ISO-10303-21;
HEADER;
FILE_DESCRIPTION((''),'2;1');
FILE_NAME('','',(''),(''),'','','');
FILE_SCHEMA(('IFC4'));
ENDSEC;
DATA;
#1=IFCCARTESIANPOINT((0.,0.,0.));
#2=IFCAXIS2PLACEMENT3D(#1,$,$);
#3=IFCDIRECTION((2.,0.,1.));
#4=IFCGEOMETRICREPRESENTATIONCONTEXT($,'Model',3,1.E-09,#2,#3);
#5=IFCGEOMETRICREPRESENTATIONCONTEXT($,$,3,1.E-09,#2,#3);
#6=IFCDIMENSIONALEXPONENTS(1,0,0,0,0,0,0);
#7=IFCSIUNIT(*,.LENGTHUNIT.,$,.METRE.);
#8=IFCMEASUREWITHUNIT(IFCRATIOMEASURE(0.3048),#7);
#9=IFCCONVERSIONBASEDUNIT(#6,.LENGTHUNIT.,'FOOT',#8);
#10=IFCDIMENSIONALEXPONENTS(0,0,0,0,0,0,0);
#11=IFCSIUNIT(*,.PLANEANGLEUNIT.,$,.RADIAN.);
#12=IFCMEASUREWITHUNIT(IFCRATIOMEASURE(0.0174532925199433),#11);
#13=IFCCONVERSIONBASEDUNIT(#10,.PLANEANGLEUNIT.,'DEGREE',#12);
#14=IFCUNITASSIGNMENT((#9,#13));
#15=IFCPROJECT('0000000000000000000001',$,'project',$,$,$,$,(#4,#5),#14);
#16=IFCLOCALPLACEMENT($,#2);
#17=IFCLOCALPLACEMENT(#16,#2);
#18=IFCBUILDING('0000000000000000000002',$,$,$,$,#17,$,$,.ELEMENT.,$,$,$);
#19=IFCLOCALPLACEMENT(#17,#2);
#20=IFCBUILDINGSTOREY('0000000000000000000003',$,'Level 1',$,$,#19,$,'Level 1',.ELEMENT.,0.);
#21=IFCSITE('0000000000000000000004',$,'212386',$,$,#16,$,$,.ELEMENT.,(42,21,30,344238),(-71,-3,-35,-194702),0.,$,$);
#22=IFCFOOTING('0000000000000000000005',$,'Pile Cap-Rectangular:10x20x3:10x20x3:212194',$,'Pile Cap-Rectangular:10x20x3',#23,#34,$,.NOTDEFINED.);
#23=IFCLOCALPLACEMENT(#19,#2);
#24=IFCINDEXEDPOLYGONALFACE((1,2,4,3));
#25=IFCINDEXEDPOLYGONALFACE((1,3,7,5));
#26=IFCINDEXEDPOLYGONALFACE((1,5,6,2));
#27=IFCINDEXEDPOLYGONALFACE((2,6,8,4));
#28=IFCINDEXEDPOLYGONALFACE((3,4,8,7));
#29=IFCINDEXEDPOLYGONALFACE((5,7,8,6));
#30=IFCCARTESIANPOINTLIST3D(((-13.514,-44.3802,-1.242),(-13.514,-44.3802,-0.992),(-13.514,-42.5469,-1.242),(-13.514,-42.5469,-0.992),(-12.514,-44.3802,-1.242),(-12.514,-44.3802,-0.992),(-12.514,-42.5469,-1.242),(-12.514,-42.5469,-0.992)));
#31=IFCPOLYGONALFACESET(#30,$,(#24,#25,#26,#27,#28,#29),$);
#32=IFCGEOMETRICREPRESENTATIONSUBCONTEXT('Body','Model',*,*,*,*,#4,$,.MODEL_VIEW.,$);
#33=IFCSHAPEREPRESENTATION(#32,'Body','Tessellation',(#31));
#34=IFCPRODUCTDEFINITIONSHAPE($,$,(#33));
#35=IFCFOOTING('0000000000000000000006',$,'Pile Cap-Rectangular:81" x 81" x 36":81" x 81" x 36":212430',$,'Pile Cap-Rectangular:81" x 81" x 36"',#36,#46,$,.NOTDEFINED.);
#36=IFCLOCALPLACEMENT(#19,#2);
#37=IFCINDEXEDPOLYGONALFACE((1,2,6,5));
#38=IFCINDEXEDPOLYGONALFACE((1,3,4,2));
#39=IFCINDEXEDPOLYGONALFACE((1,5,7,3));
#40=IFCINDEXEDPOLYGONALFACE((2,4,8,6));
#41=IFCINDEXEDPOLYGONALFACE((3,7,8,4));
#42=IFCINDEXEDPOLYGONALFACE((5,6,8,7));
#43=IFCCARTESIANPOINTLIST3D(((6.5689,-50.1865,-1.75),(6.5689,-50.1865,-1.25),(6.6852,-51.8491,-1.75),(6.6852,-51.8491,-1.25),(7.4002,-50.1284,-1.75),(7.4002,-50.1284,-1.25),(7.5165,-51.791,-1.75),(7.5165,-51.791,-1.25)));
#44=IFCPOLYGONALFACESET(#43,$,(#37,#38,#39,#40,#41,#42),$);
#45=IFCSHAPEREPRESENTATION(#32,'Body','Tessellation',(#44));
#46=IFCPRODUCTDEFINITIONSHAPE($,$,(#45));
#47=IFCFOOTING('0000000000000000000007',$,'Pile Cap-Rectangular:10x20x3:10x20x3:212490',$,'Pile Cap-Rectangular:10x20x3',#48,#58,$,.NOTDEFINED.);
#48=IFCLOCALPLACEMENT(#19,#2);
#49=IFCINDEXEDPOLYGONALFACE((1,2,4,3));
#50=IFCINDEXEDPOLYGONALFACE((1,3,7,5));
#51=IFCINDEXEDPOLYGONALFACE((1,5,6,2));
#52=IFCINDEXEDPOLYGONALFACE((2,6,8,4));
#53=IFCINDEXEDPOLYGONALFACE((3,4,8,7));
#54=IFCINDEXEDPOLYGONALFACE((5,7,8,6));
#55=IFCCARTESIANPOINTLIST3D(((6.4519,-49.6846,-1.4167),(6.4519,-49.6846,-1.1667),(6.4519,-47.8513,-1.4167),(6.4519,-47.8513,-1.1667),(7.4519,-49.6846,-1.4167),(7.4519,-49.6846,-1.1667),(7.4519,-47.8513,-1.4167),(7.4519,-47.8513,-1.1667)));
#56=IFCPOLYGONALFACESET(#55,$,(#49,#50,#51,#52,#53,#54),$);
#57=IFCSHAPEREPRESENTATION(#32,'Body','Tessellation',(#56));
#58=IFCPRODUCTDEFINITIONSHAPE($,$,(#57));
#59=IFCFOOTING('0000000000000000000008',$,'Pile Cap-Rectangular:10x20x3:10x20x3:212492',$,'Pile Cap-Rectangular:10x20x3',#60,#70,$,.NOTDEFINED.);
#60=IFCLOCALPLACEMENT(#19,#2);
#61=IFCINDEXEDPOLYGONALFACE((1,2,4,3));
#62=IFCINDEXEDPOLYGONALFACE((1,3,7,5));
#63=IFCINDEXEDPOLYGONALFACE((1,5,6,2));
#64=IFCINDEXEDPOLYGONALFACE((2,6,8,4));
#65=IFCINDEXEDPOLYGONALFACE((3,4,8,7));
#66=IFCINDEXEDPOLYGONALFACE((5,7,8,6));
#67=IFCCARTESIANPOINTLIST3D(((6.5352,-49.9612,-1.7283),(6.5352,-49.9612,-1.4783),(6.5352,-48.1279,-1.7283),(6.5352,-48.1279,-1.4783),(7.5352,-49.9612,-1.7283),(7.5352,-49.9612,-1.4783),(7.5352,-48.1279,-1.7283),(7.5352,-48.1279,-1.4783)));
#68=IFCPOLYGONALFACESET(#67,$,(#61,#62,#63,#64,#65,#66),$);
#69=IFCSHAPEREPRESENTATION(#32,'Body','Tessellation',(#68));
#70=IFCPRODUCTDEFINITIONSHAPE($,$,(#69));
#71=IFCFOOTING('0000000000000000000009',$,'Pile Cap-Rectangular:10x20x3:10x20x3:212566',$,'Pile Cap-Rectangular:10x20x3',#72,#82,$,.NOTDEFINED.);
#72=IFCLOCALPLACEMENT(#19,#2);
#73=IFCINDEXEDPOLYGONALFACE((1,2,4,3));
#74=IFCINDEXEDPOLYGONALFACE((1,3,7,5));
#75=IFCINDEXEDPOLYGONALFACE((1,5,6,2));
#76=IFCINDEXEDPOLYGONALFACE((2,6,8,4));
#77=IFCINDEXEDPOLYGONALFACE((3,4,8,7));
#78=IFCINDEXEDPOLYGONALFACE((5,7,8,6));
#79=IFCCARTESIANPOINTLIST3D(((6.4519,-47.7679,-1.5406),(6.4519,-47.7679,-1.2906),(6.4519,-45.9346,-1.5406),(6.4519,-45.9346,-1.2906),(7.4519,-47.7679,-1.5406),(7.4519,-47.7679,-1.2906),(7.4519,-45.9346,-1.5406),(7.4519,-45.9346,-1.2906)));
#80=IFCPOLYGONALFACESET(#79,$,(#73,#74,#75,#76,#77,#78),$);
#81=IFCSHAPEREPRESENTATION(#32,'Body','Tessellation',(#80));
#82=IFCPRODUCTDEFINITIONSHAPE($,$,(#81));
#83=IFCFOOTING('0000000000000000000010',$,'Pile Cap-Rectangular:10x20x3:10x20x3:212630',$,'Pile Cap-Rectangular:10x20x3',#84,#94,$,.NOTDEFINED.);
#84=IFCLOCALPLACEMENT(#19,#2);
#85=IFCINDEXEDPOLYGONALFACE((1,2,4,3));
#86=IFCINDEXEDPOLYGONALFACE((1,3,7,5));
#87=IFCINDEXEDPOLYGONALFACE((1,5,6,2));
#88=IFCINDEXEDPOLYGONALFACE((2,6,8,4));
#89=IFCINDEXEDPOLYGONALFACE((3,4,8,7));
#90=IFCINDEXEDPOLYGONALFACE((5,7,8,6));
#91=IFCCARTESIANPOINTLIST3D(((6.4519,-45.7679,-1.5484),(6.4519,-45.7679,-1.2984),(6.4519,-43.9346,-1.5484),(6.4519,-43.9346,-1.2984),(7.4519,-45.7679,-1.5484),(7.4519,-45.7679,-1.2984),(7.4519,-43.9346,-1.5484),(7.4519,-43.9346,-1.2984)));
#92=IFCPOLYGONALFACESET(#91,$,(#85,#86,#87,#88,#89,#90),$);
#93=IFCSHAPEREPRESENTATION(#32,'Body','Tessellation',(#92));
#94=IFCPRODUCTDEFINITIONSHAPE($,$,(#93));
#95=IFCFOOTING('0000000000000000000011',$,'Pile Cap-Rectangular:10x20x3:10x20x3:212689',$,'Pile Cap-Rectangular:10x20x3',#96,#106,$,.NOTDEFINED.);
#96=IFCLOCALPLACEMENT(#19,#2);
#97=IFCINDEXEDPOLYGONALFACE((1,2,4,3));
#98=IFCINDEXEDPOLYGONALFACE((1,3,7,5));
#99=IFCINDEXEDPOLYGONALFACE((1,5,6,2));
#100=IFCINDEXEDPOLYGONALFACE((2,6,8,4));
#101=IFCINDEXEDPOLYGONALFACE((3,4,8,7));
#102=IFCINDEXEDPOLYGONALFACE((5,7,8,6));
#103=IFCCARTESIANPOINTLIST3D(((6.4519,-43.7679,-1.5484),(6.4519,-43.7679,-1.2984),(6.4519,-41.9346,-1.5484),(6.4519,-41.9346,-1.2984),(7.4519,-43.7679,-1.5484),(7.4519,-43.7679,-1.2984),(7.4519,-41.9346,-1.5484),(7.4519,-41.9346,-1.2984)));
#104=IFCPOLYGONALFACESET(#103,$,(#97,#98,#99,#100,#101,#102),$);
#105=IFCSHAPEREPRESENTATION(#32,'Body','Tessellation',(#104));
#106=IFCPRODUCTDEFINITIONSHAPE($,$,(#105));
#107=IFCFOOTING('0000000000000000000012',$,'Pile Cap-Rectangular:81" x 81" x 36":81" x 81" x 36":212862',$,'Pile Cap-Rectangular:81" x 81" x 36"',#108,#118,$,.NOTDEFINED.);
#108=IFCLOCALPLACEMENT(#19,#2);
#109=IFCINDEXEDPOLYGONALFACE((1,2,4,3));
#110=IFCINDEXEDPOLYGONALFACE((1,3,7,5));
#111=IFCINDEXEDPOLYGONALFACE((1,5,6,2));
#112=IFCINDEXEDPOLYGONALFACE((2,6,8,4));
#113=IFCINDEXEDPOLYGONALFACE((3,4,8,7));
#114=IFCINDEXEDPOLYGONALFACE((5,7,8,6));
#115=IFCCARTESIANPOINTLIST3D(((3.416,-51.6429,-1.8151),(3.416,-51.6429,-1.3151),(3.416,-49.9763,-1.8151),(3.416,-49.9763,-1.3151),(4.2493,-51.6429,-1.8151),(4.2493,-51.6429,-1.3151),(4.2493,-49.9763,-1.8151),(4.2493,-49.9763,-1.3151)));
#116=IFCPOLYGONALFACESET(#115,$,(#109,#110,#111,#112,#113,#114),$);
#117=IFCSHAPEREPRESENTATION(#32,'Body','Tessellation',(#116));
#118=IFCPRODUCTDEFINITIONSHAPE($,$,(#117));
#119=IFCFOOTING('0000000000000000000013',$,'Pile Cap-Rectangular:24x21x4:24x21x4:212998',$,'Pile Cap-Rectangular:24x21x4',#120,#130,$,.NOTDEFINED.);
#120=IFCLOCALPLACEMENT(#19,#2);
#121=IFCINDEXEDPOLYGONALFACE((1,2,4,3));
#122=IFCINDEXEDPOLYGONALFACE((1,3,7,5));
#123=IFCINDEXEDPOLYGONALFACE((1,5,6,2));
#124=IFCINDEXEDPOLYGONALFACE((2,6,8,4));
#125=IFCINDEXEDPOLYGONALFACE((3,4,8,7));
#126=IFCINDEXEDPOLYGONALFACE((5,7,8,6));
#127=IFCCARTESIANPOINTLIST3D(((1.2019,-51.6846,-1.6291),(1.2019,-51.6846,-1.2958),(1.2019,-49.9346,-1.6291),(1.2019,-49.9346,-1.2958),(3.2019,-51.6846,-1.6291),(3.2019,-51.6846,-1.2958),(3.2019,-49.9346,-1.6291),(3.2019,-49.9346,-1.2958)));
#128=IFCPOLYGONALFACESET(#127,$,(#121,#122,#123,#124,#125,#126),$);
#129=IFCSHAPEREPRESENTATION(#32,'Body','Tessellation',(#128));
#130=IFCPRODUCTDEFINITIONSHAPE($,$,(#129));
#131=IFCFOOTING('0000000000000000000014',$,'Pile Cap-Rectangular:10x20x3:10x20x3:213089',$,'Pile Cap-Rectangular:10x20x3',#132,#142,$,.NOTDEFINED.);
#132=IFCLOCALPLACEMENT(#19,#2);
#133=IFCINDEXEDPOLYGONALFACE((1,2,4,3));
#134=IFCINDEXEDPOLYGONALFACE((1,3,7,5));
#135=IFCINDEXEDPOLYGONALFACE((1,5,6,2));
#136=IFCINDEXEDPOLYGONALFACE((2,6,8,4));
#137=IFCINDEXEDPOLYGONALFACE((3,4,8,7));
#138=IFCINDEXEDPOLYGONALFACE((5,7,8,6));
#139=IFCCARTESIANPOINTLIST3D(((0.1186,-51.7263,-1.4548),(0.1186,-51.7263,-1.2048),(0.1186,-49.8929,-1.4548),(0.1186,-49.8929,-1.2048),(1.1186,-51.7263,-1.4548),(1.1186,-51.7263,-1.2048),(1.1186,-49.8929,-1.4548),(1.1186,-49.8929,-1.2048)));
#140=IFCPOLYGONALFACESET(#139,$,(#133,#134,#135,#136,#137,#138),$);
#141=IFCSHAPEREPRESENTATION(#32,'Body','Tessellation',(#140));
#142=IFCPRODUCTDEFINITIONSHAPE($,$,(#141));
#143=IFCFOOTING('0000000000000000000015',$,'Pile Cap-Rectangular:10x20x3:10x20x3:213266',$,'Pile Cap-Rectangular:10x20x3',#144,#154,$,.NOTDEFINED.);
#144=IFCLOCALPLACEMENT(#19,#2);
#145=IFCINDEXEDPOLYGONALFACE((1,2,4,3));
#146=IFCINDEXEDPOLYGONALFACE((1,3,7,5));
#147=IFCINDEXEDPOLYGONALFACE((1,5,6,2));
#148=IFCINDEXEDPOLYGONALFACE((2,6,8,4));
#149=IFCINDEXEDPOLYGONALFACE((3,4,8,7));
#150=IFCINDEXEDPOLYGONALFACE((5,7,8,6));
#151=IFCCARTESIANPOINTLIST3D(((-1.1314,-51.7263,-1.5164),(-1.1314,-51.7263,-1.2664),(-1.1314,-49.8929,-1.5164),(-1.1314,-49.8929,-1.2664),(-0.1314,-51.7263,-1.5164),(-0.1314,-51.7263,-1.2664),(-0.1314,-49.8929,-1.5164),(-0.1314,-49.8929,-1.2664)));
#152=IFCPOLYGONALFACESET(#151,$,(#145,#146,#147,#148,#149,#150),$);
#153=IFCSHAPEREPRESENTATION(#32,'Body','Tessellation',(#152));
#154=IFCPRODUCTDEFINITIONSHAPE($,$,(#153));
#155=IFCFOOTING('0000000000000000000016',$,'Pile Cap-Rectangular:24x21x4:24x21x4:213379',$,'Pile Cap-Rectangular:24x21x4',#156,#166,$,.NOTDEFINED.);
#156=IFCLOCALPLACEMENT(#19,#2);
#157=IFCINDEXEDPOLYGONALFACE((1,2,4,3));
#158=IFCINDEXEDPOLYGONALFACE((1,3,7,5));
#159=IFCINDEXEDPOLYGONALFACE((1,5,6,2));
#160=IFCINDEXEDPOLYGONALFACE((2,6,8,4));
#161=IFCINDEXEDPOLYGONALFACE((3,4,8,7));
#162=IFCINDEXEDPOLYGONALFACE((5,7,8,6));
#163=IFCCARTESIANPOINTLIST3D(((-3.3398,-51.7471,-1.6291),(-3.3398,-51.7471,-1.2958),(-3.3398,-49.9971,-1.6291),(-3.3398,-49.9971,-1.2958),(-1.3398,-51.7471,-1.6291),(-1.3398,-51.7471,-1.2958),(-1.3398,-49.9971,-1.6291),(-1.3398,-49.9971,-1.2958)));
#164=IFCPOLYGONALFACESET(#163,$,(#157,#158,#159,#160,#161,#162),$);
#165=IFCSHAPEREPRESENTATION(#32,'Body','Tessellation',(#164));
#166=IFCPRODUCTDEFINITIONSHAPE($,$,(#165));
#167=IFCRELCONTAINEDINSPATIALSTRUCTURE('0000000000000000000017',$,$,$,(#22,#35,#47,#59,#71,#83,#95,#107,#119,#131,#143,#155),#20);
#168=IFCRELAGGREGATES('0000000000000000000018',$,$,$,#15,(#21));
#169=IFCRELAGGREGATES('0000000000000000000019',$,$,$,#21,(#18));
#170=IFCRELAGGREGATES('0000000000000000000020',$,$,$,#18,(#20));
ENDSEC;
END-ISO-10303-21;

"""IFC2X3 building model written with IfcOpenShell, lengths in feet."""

from ifc_helpers import new_model, entity, si_unit, converted_unit, direction, frame, frame_2d, origin, origin_2d_with_axis, place, context, subcontext, project, spatial, rectangle, extrude, element, save


model = new_model("IFC2X3")

# Units and contexts
model_context = context("Model", 3, precision=1e-09, world=origin(), true_north=direction((2.0, 0.0, 1.0)))
context_of_model = context(None, 3, precision=1e-09, world=origin(), true_north=direction((2.0, 0.0, 1.0)))
body_context = subcontext(model_context, "Body", "Model", "MODEL_VIEW")
ifc_project = project(units=[converted_unit("LENGTHUNIT", "FOOT", entity("IfcRatioMeasure", 0.3048), si_unit("LENGTHUNIT", "METRE"), dimensions=[1, 0, 0, 0, 0, 0, 0]), converted_unit("PLANEANGLEUNIT", "DEGREE", entity("IfcRatioMeasure", 0.0174532925199433), si_unit("PLANEANGLEUNIT", "RADIAN"), dimensions=[0, 0, 0, 0, 0, 0, 0])], contexts=[model_context, context_of_model])

# Site, building, storey
site_placement = place(None, origin())
site = spatial("IfcSite", under=ifc_project, at=site_placement, Name="212386", CompositionType="ELEMENT", RefLatitude=(42, 21, 30, 344238), RefLongitude=(-71, -3, -35, -194702), RefElevation=0.0)
building_placement = place(site_placement, origin())
building = spatial("IfcBuilding", under=site, at=building_placement, CompositionType="ELEMENT")
storey_placement = place(building_placement, origin())
storey = spatial("IfcBuildingStorey", under=building, at=storey_placement, Name="Level 1", LongName="Level 1", CompositionType="ELEMENT", Elevation=0.0)

# Footings
footing_1_placement = place(storey_placement, origin())
element("IfcFooting", 1, at=footing_1_placement, inside=storey, Name="Pile Cap-Rectangular:10x20x3:10x20x3:212194", ObjectType="Pile Cap-Rectangular:10x20x3", PredefinedType="NOTDEFINED", context=body_context, shape_type="SweptSolid", body=[
    extrude(rectangle(XDim=1.0, YDim=1.8333, at=frame_2d((0.0, 0.0), x_axis=(1.0, 0.0))), frame((-13.014, -43.4636, -1.242), z_axis=(0.0, 0.0, 1.0), x_axis=(-1.0, 0.0, 0.0)), (0.0, 0.0, 1.0), 0.25),
])
footing_2_placement = place(storey_placement, origin())
element("IfcFooting", 2, at=footing_2_placement, inside=storey, Name="Pile Cap-Rectangular:81\" x 81\" x 36\":81\" x 81\" x 36\":212430", ObjectType="Pile Cap-Rectangular:81\" x 81\" x 36\"", PredefinedType="NOTDEFINED", context=body_context, shape_type="SweptSolid", body=[
    extrude(rectangle(XDim=0.8333, YDim=1.6667, at=origin_2d_with_axis()), frame((7.0427, -50.9887, -1.75), z_axis=(0.0, 0.0, 1.0), x_axis=(-0.997564, -0.069756, 0.0)), (0.0, 0.0, 1.0), 0.5),
])
footing_3_placement = place(storey_placement, origin())
element("IfcFooting", 3, at=footing_3_placement, inside=storey, Name="Pile Cap-Rectangular:10x20x3:10x20x3:212490", ObjectType="Pile Cap-Rectangular:10x20x3", PredefinedType="NOTDEFINED", context=body_context, shape_type="SweptSolid", body=[
    extrude(rectangle(XDim=1.0, YDim=1.8333, at=frame_2d((0.0, 0.0), x_axis=(1.0, 0.0))), frame((6.9519, -48.7679, -1.4167), z_axis=(0.0, 0.0, 1.0), x_axis=(-1.0, 0.0, 0.0)), (0.0, 0.0, 1.0), 0.25),
])
footing_4_placement = place(storey_placement, origin())
element("IfcFooting", 4, at=footing_4_placement, inside=storey, Name="Pile Cap-Rectangular:10x20x3:10x20x3:212492", ObjectType="Pile Cap-Rectangular:10x20x3", PredefinedType="NOTDEFINED", context=body_context, shape_type="SweptSolid", body=[
    extrude(rectangle(XDim=1.0, YDim=1.8333, at=frame_2d((0.0, 0.0), x_axis=(1.0, 0.0))), frame((7.0352, -49.0446, -1.7283), z_axis=(0.0, 0.0, 1.0), x_axis=(-1.0, 0.0, 0.0)), (0.0, 0.0, 1.0), 0.25),
])
footing_5_placement = place(storey_placement, origin())
element("IfcFooting", 5, at=footing_5_placement, inside=storey, Name="Pile Cap-Rectangular:10x20x3:10x20x3:212566", ObjectType="Pile Cap-Rectangular:10x20x3", PredefinedType="NOTDEFINED", context=body_context, shape_type="SweptSolid", body=[
    extrude(rectangle(XDim=1.0, YDim=1.8333, at=frame_2d((0.0, 0.0), x_axis=(1.0, 0.0))), frame((6.9519, -46.8513, -1.5406), z_axis=(0.0, 0.0, 1.0), x_axis=(-1.0, 0.0, 0.0)), (0.0, 0.0, 1.0), 0.25),
])
footing_6_placement = place(storey_placement, origin())
element("IfcFooting", 6, at=footing_6_placement, inside=storey, Name="Pile Cap-Rectangular:10x20x3:10x20x3:212630", ObjectType="Pile Cap-Rectangular:10x20x3", PredefinedType="NOTDEFINED", context=body_context, shape_type="SweptSolid", body=[
    extrude(rectangle(XDim=1.0, YDim=1.8333, at=frame_2d((0.0, 0.0), x_axis=(1.0, 0.0))), frame((6.9519, -44.8513, -1.5484), z_axis=(0.0, 0.0, 1.0), x_axis=(-1.0, 0.0, 0.0)), (0.0, 0.0, 1.0), 0.25),
])
footing_7_placement = place(storey_placement, origin())
element("IfcFooting", 7, at=footing_7_placement, inside=storey, Name="Pile Cap-Rectangular:10x20x3:10x20x3:212689", ObjectType="Pile Cap-Rectangular:10x20x3", PredefinedType="NOTDEFINED", context=body_context, shape_type="SweptSolid", body=[
    extrude(rectangle(XDim=1.0, YDim=1.8333, at=frame_2d((0.0, 0.0), x_axis=(1.0, 0.0))), frame((6.9519, -42.8513, -1.5484), z_axis=(0.0, 0.0, 1.0), x_axis=(-1.0, 0.0, 0.0)), (0.0, 0.0, 1.0), 0.25),
])
footing_8_placement = place(storey_placement, origin())
element("IfcFooting", 8, at=footing_8_placement, inside=storey, Name="Pile Cap-Rectangular:81\" x 81\" x 36\":81\" x 81\" x 36\":212862", ObjectType="Pile Cap-Rectangular:81\" x 81\" x 36\"", PredefinedType="NOTDEFINED", context=body_context, shape_type="SweptSolid", body=[
    extrude(rectangle(XDim=0.8333, YDim=1.6667, at=frame_2d((0.0, 0.0), x_axis=(1.0, 0.0))), frame((3.8327, -50.8096, -1.8151), z_axis=(0.0, 0.0, 1.0), x_axis=(-1.0, 0.0, 0.0)), (0.0, 0.0, 1.0), 0.5),
])
footing_9_placement = place(storey_placement, origin())
element("IfcFooting", 9, at=footing_9_placement, inside=storey, Name="Pile Cap-Rectangular:24x21x4:24x21x4:212998", ObjectType="Pile Cap-Rectangular:24x21x4", PredefinedType="NOTDEFINED", context=body_context, shape_type="SweptSolid", body=[
    extrude(rectangle(XDim=2.0, YDim=1.75, at=origin_2d_with_axis()), frame((2.2019, -50.8096, -1.6291), z_axis=(0.0, 0.0, 1.0), x_axis=(-1.0, 0.0, 0.0)), (0.0, 0.0, 1.0), 0.3333),
])
footing_10_placement = place(storey_placement, origin())
element("IfcFooting", 10, at=footing_10_placement, inside=storey, Name="Pile Cap-Rectangular:10x20x3:10x20x3:213089", ObjectType="Pile Cap-Rectangular:10x20x3", PredefinedType="NOTDEFINED", context=body_context, shape_type="SweptSolid", body=[
    extrude(rectangle(XDim=1.0, YDim=1.8333, at=frame_2d((0.0, 0.0), x_axis=(1.0, 0.0))), frame((0.6186, -50.8096, -1.4548), z_axis=(0.0, 0.0, 1.0), x_axis=(-1.0, 0.0, 0.0)), (0.0, 0.0, 1.0), 0.25),
])
footing_11_placement = place(storey_placement, origin())
element("IfcFooting", 11, at=footing_11_placement, inside=storey, Name="Pile Cap-Rectangular:10x20x3:10x20x3:213266", ObjectType="Pile Cap-Rectangular:10x20x3", PredefinedType="NOTDEFINED", context=body_context, shape_type="SweptSolid", body=[
    extrude(rectangle(XDim=1.0, YDim=1.8333, at=frame_2d((0.0, 0.0), x_axis=(1.0, 0.0))), frame((-0.6314, -50.8096, -1.5164), z_axis=(0.0, 0.0, 1.0), x_axis=(-1.0, 0.0, 0.0)), (0.0, 0.0, 1.0), 0.25),
])
footing_12_placement = place(storey_placement, origin())
element("IfcFooting", 12, at=footing_12_placement, inside=storey, Name="Pile Cap-Rectangular:24x21x4:24x21x4:213379", ObjectType="Pile Cap-Rectangular:24x21x4", PredefinedType="NOTDEFINED", context=body_context, shape_type="SweptSolid", body=[
    extrude(rectangle(XDim=2.0, YDim=1.75, at=origin_2d_with_axis()), frame((-2.3398, -50.8721, -1.6291), z_axis=(0.0, 0.0, 1.0), x_axis=(-1.0, 0.0, 0.0)), (0.0, 0.0, 1.0), 0.3333),
])

save(model, "model.ifc")
